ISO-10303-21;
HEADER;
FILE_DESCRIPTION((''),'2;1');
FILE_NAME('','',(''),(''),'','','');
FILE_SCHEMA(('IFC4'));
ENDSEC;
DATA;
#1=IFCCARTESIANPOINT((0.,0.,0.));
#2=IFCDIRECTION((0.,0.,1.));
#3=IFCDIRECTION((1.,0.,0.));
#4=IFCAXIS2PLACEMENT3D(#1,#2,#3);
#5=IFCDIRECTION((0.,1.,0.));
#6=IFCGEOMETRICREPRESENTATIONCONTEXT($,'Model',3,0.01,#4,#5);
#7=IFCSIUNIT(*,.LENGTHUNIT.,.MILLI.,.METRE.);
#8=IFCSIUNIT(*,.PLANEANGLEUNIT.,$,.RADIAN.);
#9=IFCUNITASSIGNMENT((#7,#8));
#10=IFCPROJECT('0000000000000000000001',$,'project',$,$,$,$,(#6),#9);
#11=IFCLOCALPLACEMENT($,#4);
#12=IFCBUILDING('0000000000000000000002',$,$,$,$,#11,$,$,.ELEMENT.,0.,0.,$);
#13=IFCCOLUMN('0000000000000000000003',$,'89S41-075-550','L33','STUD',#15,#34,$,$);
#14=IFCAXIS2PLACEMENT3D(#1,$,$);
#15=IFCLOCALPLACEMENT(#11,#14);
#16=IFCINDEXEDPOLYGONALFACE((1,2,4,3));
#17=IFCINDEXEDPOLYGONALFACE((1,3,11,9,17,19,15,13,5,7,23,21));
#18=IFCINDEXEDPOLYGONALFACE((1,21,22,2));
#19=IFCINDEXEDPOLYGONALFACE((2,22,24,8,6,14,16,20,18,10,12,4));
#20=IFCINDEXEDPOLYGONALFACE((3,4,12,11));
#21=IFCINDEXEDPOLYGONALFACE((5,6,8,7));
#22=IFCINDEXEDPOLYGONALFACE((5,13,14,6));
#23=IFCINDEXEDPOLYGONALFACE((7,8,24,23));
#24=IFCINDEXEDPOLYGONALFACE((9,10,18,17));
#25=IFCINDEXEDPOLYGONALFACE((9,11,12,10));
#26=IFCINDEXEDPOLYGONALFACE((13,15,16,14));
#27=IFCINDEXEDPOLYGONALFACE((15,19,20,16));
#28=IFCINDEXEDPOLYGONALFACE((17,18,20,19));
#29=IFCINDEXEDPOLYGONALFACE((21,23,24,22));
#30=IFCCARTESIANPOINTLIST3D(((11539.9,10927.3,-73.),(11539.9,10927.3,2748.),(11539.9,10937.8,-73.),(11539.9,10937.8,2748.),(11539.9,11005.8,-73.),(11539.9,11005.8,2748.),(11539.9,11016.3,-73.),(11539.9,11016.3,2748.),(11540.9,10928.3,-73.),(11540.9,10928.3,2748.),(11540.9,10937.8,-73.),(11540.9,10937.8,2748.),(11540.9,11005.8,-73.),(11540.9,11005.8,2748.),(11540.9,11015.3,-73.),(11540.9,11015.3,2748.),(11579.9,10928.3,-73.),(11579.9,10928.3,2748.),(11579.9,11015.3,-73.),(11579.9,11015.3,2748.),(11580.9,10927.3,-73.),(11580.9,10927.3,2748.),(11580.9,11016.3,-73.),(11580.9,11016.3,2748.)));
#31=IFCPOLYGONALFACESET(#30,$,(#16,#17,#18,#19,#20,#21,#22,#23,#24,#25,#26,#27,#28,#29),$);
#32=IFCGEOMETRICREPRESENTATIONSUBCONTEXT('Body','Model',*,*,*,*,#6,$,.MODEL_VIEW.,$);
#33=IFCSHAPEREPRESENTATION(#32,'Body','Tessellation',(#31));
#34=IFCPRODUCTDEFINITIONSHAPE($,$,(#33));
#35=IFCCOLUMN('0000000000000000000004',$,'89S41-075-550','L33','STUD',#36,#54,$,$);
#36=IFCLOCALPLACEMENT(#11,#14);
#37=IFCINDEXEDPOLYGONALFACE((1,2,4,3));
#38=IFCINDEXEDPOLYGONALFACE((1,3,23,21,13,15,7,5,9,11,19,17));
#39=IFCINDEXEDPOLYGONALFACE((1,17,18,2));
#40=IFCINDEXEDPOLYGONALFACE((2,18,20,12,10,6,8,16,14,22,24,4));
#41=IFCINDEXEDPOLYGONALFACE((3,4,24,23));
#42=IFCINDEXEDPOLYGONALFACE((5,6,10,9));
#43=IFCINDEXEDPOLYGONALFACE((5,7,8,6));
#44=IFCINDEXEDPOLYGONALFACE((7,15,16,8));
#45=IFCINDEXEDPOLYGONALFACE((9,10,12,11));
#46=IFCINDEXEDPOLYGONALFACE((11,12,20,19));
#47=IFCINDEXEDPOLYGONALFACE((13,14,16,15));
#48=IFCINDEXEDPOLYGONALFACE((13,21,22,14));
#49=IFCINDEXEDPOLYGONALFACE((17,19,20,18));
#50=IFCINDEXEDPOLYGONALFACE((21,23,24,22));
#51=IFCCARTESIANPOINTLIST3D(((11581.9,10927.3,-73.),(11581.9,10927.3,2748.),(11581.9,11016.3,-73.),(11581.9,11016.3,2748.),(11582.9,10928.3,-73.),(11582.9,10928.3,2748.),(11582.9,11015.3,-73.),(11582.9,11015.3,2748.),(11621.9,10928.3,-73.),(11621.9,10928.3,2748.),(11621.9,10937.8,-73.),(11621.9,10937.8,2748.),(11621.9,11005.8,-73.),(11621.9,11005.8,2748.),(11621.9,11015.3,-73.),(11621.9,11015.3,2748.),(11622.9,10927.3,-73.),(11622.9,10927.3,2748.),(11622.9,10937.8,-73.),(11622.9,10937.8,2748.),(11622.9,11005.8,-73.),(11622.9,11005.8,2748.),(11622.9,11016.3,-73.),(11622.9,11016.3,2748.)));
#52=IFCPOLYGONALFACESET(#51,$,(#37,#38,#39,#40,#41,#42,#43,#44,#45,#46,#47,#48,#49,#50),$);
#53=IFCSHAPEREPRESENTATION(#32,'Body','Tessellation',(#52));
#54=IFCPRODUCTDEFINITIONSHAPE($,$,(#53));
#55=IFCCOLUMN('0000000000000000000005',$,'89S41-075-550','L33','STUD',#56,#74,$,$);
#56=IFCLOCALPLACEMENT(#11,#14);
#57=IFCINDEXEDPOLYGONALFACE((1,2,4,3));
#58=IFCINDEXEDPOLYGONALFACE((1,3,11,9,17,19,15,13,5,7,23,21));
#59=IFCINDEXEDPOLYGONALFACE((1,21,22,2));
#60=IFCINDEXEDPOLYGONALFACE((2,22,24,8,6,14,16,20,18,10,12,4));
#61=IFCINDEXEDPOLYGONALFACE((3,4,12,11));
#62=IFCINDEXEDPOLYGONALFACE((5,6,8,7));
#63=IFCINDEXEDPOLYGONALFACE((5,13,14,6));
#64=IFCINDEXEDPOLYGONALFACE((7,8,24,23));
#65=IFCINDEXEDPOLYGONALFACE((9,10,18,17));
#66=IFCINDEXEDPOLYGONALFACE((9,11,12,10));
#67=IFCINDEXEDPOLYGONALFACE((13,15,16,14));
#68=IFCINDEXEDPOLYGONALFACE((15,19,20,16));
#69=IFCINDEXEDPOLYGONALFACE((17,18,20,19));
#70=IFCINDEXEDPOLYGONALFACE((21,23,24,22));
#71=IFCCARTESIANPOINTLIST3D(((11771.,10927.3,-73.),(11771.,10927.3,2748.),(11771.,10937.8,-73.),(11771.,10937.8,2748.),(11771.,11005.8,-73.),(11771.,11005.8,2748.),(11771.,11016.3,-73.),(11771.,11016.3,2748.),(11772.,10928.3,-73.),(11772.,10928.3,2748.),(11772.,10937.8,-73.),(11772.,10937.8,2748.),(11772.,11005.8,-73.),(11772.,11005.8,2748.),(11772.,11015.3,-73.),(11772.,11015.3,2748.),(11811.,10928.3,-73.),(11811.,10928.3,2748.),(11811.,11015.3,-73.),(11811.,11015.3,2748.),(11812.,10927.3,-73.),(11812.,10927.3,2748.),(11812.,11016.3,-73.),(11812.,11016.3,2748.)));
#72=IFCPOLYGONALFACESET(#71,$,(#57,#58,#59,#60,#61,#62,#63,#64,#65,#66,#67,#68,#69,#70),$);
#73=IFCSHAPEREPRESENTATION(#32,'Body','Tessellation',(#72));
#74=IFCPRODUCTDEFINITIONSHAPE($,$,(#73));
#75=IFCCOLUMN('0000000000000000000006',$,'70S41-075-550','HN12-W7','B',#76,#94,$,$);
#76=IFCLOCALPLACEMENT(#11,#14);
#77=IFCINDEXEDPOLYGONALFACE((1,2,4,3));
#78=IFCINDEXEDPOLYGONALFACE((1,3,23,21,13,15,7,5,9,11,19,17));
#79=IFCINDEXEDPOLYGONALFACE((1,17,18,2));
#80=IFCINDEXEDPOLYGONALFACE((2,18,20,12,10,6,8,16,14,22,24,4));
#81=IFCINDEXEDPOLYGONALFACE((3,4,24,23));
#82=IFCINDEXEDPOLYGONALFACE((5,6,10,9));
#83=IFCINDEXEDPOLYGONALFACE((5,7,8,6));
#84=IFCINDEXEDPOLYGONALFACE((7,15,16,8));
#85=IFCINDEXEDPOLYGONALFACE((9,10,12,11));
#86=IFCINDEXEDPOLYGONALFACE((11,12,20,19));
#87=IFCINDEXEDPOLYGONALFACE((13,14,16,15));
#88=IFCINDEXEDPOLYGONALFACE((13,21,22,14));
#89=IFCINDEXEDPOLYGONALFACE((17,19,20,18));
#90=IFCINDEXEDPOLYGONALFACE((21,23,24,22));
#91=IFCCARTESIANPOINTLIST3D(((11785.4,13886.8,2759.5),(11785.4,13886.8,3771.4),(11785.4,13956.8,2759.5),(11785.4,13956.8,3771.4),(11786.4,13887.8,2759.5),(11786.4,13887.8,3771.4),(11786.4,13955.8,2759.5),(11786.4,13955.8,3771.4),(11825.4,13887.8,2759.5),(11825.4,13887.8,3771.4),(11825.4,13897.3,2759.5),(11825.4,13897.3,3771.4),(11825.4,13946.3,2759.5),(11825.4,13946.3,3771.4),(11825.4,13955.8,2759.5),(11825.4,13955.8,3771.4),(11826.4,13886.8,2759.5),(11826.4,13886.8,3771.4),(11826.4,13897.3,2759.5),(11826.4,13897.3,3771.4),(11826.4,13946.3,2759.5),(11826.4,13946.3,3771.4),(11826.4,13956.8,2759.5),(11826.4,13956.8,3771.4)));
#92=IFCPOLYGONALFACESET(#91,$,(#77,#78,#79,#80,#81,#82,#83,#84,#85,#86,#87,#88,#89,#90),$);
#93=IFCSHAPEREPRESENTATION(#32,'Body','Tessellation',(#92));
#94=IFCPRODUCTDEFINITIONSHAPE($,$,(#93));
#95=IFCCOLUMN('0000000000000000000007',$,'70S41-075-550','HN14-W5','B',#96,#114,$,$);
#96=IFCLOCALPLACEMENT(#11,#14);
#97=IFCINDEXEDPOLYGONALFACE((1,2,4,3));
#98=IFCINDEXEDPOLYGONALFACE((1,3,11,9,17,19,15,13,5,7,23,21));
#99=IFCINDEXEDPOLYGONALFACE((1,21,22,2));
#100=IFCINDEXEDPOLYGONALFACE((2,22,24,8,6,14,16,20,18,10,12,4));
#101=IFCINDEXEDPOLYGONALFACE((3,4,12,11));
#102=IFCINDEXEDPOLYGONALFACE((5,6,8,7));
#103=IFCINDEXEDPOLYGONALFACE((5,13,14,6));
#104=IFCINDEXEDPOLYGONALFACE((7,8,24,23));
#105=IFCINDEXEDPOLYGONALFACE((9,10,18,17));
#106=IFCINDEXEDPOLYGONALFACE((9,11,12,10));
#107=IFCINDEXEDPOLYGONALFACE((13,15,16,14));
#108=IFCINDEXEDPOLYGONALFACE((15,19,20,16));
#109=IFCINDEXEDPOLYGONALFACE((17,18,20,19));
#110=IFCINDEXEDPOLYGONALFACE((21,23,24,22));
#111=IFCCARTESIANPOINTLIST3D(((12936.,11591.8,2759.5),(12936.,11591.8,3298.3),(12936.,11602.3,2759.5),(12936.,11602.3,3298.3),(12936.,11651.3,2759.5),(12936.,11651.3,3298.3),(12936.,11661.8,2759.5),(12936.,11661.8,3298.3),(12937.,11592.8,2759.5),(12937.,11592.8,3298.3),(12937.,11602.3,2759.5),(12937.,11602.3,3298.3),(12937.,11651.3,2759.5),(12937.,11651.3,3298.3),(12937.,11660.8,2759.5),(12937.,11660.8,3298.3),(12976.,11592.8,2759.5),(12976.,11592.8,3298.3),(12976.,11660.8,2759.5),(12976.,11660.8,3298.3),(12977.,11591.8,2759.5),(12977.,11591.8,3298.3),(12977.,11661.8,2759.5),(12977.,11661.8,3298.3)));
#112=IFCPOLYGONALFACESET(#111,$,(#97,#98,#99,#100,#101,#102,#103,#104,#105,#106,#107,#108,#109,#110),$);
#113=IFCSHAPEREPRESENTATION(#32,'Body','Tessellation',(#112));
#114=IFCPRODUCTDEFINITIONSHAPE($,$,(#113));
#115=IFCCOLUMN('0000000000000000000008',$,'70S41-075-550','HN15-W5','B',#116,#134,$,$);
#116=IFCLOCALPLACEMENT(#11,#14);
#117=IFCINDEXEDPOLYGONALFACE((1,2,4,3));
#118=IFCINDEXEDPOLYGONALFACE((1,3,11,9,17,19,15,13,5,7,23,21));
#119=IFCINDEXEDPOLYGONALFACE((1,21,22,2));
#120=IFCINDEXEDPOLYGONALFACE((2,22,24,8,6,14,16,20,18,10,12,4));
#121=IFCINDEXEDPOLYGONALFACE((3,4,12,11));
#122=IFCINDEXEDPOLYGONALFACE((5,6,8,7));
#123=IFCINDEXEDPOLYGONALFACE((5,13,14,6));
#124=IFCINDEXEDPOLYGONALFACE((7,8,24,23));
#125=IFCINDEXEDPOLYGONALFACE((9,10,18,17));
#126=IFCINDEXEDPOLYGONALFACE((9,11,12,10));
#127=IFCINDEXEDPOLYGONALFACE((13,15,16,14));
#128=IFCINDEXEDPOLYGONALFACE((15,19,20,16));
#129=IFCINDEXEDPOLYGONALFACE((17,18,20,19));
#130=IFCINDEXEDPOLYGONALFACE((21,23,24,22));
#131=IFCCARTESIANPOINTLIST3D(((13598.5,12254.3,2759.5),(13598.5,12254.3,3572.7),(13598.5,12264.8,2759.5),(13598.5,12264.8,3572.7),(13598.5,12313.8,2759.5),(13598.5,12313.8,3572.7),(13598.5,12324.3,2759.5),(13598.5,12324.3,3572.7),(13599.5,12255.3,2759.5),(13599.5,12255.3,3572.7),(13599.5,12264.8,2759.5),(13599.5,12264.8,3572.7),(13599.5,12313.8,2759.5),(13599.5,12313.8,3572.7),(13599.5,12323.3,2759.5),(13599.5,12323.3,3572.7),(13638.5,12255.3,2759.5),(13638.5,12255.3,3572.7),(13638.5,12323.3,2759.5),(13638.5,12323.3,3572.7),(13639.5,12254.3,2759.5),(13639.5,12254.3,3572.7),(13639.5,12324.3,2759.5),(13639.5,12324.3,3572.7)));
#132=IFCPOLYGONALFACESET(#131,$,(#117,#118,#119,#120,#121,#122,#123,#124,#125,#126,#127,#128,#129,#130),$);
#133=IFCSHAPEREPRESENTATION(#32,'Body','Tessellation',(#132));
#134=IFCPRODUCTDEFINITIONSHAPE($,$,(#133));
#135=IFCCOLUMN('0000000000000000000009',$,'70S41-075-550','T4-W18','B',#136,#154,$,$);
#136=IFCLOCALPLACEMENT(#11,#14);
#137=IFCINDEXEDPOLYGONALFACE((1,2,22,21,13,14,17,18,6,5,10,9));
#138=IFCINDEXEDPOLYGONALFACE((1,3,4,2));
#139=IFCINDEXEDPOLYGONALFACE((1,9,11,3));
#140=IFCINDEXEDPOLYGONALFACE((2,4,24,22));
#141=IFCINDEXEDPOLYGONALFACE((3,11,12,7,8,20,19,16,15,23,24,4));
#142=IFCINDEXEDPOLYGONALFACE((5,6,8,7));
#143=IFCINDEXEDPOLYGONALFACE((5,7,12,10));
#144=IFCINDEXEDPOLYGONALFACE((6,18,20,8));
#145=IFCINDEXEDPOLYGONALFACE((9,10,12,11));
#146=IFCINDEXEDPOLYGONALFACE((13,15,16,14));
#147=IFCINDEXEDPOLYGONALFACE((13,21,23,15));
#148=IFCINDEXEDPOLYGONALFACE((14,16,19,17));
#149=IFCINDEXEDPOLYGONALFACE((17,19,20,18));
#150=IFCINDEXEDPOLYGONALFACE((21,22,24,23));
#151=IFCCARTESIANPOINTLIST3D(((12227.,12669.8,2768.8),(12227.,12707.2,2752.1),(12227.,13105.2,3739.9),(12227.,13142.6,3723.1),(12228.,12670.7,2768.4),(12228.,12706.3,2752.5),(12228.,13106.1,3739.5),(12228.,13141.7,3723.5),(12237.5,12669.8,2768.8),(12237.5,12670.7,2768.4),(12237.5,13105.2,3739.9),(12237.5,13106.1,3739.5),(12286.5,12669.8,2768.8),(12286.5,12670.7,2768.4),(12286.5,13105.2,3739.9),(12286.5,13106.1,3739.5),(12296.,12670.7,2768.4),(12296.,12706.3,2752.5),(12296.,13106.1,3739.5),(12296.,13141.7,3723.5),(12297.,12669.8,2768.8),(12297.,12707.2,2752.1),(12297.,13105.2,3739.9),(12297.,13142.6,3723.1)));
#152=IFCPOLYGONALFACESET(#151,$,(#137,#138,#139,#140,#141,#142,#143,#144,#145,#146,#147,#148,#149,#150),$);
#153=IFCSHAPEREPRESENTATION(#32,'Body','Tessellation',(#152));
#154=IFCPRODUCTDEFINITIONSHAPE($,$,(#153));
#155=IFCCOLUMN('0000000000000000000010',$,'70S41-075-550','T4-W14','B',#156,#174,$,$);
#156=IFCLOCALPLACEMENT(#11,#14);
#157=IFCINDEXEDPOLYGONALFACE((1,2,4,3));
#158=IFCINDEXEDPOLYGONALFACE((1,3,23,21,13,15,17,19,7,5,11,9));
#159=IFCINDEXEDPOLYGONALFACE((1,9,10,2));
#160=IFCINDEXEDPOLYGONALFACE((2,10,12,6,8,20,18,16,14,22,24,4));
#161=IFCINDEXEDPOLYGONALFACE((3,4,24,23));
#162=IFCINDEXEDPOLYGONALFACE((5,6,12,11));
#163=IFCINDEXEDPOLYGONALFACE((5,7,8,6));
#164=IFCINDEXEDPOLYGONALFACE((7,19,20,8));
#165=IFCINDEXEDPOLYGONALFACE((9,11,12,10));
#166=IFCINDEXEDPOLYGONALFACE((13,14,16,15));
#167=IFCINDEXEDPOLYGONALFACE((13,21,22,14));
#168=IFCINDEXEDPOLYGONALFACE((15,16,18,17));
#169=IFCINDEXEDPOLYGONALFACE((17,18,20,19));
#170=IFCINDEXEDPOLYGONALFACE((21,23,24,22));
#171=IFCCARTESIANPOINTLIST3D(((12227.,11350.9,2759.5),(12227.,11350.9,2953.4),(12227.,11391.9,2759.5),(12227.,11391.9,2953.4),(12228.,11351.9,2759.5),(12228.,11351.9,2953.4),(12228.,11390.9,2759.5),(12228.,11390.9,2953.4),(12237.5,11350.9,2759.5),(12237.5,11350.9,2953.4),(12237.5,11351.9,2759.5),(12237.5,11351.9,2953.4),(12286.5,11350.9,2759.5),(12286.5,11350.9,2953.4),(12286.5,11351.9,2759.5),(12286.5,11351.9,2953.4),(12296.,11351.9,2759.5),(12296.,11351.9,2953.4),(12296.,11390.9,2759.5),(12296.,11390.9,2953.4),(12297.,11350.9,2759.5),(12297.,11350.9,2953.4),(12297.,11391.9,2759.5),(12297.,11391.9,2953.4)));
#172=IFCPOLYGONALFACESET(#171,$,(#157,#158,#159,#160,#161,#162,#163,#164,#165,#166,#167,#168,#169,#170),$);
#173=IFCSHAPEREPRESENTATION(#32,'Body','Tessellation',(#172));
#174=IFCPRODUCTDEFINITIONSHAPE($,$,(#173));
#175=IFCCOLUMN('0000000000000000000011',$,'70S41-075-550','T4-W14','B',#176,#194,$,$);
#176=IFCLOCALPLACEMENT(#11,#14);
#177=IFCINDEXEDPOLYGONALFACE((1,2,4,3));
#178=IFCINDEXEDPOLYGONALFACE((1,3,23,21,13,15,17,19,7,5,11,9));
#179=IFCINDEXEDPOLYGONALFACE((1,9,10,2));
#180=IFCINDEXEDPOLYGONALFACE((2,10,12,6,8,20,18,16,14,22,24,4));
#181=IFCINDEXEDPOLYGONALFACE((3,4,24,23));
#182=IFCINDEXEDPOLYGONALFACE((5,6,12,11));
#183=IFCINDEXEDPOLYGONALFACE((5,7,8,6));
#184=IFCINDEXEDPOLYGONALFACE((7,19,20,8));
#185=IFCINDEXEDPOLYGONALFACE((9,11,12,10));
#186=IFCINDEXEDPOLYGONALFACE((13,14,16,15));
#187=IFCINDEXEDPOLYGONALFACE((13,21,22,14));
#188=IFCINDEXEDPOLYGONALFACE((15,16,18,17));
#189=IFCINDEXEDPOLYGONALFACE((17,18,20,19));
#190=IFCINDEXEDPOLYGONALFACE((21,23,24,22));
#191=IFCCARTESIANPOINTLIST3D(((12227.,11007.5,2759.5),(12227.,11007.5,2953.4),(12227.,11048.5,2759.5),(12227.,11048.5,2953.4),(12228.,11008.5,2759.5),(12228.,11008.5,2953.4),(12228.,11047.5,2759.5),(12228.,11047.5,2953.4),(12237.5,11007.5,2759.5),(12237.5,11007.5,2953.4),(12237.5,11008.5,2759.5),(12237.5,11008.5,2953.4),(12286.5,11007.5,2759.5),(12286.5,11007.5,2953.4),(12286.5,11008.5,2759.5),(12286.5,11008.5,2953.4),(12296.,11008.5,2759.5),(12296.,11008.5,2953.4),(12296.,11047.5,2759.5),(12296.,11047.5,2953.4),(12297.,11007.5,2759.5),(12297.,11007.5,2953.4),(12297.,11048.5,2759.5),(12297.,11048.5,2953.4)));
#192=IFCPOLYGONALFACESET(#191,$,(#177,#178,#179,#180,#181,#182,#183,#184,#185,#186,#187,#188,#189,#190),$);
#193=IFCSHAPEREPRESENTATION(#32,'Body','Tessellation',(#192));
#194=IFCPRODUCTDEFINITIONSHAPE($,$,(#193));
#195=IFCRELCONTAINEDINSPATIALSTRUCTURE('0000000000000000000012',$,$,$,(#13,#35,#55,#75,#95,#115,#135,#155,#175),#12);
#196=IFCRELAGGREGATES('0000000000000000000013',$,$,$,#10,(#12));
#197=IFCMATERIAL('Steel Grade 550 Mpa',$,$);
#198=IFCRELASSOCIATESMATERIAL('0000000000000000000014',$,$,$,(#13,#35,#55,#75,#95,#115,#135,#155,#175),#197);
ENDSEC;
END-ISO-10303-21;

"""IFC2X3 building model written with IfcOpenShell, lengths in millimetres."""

from ifc_helpers import new_model, si_unit, direction, frame, origin, origin_with_axes, origin_2d_with_axis, place, context, subcontext, project, spatial, c_section, extrude, source, transform, mapped, material, element, save


model = new_model("IFC2X3")

# Units and contexts
model_context = context("Model", 3, precision=0.01, world=origin_with_axes(), true_north=direction((0.0, 1.0, 0.0)))
body_context = subcontext(model_context, "Body", "Model", "MODEL_VIEW")
ifc_project = project(units=[si_unit("LENGTHUNIT", "METRE", prefix="MILLI"), si_unit("PLANEANGLEUNIT", "RADIAN")], contexts=[model_context])

# Building
building_placement = place(None, origin_with_axes())
building = spatial("IfcBuilding", under=ifc_project, at=building_placement, CompositionType="ELEMENT", ElevationOfRefHeight=0.0, ElevationOfTerrain=0.0)

# Columns
ifc_material = material(Name="Steel Grade 550 Mpa")
shared_shape_1 = source(origin(), body_context, "Body", "SweptSolid", [
    extrude(c_section(Depth=89.0, Width=41.0, WallThickness=1.0, Girth=10.5, at=origin_2d_with_axis()), origin_with_axes(), (0.0, 0.0, 1.0), 2821.0),
])
column_1_placement = place(None, frame((11560.4, 10971.8, -73.0), z_axis=(0.0, 0.0, 1.0), x_axis=(-1.0, 0.0, 0.0)))
element("IfcColumn", 1, at=column_1_placement, inside=building, material=ifc_material, Name="89S41-075-550", Description="L33", ObjectType="STUD", context=body_context, shape_type="MappedRepresentation", body=[
    mapped(shared_shape_1, transform((0.0, 0.0, 0.0), scale=1.0)),
])
shared_shape_2 = source(origin(), body_context, "Body", "SweptSolid", [
    extrude(c_section(Depth=89.0, Width=41.0, WallThickness=1.0, Girth=10.5, at=origin_2d_with_axis()), origin_with_axes(), (0.0, 0.0, 1.0), 2821.0),
])
column_2_placement = place(None, frame((11602.4, 10971.8, -73.0), z_axis=(0.0, 0.0, 1.0), x_axis=(1.0, 0.0, 0.0)))
element("IfcColumn", 2, at=column_2_placement, inside=building, material=ifc_material, Name="89S41-075-550", Description="L33", ObjectType="STUD", context=body_context, shape_type="MappedRepresentation", body=[
    mapped(shared_shape_2, transform((0.0, 0.0, 0.0), scale=1.0)),
])
shared_shape_3 = source(origin(), body_context, "Body", "SweptSolid", [
    extrude(c_section(Depth=89.0, Width=41.0, WallThickness=1.0, Girth=10.5, at=origin_2d_with_axis()), origin_with_axes(), (0.0, 0.0, 1.0), 2821.0),
])
column_3_placement = place(None, frame((11791.5, 10971.8, -73.0), z_axis=(0.0, 0.0, 1.0), x_axis=(-1.0, 0.0, 0.0)))
element("IfcColumn", 3, at=column_3_placement, inside=building, material=ifc_material, Name="89S41-075-550", Description="L33", ObjectType="STUD", context=body_context, shape_type="MappedRepresentation", body=[
    mapped(shared_shape_3, transform((0.0, 0.0, 0.0), scale=1.0)),
])
shared_shape_4 = source(origin(), body_context, "Body", "SweptSolid", [
    extrude(c_section(Depth=70.0, Width=41.0, WallThickness=1.0, Girth=10.5, at=origin_2d_with_axis()), origin_with_axes(), (0.0, 0.0, 1.0), 1011.9),
])
column_4_placement = place(None, frame((11805.9, 13921.8, 2759.5), z_axis=(0.0, 0.0, 1.0), x_axis=(1.0, 0.0, 0.0)))
element("IfcColumn", 4, at=column_4_placement, inside=building, material=ifc_material, Name="70S41-075-550", Description="HN12-W7", ObjectType="B", context=body_context, shape_type="MappedRepresentation", body=[
    mapped(shared_shape_4, transform((0.0, 0.0, 0.0), scale=1.0)),
])
shared_shape_5 = source(origin(), body_context, "Body", "SweptSolid", [
    extrude(c_section(Depth=70.0, Width=41.0, WallThickness=1.0, Girth=10.5, at=origin_2d_with_axis()), origin_with_axes(), (0.0, 0.0, 1.0), 538.8),
])
column_5_placement = place(None, frame((12956.5, 11626.8, 2759.5), z_axis=(0.0, 0.0, 1.0), x_axis=(-1.0, -0.000004, 0.0)))
element("IfcColumn", 5, at=column_5_placement, inside=building, material=ifc_material, Name="70S41-075-550", Description="HN14-W5", ObjectType="B", context=body_context, shape_type="MappedRepresentation", body=[
    mapped(shared_shape_5, transform((0.0, 0.0, 0.0), scale=1.0)),
])
shared_shape_6 = source(origin(), body_context, "Body", "SweptSolid", [
    extrude(c_section(Depth=70.0, Width=41.0, WallThickness=1.0, Girth=10.5, at=origin_2d_with_axis()), origin_with_axes(), (0.0, 0.0, 1.0), 813.2),
])
column_6_placement = place(None, frame((13619.0, 12289.3, 2759.5), z_axis=(0.0, 0.0, 1.0), x_axis=(-1.0, -0.000004, 0.0)))
element("IfcColumn", 6, at=column_6_placement, inside=building, material=ifc_material, Name="70S41-075-550", Description="HN15-W5", ObjectType="B", context=body_context, shape_type="MappedRepresentation", body=[
    mapped(shared_shape_6, transform((0.0, 0.0, 0.0), scale=1.0)),
])
shared_shape_7 = source(origin(), body_context, "Body", "SweptSolid", [
    extrude(c_section(Depth=70.0, Width=41.0, WallThickness=1.0, Girth=10.5, at=origin_2d_with_axis()), origin_with_axes(), (0.0, 0.0, 1.0), 1064.1),
])
column_7_placement = place(None, frame((12262.0, 12688.5, 2760.5), z_axis=(0.0, 0.409121, 0.91248), x_axis=(0.0, -0.91248, 0.409121)))
element("IfcColumn", 7, at=column_7_placement, inside=building, material=ifc_material, Name="70S41-075-550", Description="T4-W18", ObjectType="B", context=body_context, shape_type="MappedRepresentation", body=[
    mapped(shared_shape_7, transform((0.0, 0.0, 0.0), scale=1.0)),
])
shared_shape_8 = source(origin(), body_context, "Body", "SweptSolid", [
    extrude(c_section(Depth=70.0, Width=41.0, WallThickness=1.0, Girth=10.5, at=origin_2d_with_axis()), origin_with_axes(), (0.0, 0.0, 1.0), 193.9),
])
column_8_placement = place(None, frame((12262.0, 11371.4, 2759.5), z_axis=(0.0, 0.0, 1.0), x_axis=(0.0, -1.0, 0.0)))
element("IfcColumn", 8, at=column_8_placement, inside=building, material=ifc_material, Name="70S41-075-550", Description="T4-W14", ObjectType="B", context=body_context, shape_type="MappedRepresentation", body=[
    mapped(shared_shape_8, transform((0.0, 0.0, 0.0), scale=1.0)),
])
shared_shape_9 = source(origin(), body_context, "Body", "SweptSolid", [
    extrude(c_section(Depth=70.0, Width=41.0, WallThickness=1.0, Girth=10.5, at=origin_2d_with_axis()), origin_with_axes(), (0.0, 0.0, 1.0), 193.9),
])
column_9_placement = place(None, frame((12262.0, 11028.0, 2759.5), z_axis=(0.0, 0.0, 1.0), x_axis=(0.0, -1.0, 0.0)))
element("IfcColumn", 9, at=column_9_placement, inside=building, material=ifc_material, Name="70S41-075-550", Description="T4-W14", ObjectType="B", context=body_context, shape_type="MappedRepresentation", body=[
    mapped(shared_shape_9, transform((0.0, 0.0, 0.0), scale=1.0)),
])

save(model, "model.ifc")
